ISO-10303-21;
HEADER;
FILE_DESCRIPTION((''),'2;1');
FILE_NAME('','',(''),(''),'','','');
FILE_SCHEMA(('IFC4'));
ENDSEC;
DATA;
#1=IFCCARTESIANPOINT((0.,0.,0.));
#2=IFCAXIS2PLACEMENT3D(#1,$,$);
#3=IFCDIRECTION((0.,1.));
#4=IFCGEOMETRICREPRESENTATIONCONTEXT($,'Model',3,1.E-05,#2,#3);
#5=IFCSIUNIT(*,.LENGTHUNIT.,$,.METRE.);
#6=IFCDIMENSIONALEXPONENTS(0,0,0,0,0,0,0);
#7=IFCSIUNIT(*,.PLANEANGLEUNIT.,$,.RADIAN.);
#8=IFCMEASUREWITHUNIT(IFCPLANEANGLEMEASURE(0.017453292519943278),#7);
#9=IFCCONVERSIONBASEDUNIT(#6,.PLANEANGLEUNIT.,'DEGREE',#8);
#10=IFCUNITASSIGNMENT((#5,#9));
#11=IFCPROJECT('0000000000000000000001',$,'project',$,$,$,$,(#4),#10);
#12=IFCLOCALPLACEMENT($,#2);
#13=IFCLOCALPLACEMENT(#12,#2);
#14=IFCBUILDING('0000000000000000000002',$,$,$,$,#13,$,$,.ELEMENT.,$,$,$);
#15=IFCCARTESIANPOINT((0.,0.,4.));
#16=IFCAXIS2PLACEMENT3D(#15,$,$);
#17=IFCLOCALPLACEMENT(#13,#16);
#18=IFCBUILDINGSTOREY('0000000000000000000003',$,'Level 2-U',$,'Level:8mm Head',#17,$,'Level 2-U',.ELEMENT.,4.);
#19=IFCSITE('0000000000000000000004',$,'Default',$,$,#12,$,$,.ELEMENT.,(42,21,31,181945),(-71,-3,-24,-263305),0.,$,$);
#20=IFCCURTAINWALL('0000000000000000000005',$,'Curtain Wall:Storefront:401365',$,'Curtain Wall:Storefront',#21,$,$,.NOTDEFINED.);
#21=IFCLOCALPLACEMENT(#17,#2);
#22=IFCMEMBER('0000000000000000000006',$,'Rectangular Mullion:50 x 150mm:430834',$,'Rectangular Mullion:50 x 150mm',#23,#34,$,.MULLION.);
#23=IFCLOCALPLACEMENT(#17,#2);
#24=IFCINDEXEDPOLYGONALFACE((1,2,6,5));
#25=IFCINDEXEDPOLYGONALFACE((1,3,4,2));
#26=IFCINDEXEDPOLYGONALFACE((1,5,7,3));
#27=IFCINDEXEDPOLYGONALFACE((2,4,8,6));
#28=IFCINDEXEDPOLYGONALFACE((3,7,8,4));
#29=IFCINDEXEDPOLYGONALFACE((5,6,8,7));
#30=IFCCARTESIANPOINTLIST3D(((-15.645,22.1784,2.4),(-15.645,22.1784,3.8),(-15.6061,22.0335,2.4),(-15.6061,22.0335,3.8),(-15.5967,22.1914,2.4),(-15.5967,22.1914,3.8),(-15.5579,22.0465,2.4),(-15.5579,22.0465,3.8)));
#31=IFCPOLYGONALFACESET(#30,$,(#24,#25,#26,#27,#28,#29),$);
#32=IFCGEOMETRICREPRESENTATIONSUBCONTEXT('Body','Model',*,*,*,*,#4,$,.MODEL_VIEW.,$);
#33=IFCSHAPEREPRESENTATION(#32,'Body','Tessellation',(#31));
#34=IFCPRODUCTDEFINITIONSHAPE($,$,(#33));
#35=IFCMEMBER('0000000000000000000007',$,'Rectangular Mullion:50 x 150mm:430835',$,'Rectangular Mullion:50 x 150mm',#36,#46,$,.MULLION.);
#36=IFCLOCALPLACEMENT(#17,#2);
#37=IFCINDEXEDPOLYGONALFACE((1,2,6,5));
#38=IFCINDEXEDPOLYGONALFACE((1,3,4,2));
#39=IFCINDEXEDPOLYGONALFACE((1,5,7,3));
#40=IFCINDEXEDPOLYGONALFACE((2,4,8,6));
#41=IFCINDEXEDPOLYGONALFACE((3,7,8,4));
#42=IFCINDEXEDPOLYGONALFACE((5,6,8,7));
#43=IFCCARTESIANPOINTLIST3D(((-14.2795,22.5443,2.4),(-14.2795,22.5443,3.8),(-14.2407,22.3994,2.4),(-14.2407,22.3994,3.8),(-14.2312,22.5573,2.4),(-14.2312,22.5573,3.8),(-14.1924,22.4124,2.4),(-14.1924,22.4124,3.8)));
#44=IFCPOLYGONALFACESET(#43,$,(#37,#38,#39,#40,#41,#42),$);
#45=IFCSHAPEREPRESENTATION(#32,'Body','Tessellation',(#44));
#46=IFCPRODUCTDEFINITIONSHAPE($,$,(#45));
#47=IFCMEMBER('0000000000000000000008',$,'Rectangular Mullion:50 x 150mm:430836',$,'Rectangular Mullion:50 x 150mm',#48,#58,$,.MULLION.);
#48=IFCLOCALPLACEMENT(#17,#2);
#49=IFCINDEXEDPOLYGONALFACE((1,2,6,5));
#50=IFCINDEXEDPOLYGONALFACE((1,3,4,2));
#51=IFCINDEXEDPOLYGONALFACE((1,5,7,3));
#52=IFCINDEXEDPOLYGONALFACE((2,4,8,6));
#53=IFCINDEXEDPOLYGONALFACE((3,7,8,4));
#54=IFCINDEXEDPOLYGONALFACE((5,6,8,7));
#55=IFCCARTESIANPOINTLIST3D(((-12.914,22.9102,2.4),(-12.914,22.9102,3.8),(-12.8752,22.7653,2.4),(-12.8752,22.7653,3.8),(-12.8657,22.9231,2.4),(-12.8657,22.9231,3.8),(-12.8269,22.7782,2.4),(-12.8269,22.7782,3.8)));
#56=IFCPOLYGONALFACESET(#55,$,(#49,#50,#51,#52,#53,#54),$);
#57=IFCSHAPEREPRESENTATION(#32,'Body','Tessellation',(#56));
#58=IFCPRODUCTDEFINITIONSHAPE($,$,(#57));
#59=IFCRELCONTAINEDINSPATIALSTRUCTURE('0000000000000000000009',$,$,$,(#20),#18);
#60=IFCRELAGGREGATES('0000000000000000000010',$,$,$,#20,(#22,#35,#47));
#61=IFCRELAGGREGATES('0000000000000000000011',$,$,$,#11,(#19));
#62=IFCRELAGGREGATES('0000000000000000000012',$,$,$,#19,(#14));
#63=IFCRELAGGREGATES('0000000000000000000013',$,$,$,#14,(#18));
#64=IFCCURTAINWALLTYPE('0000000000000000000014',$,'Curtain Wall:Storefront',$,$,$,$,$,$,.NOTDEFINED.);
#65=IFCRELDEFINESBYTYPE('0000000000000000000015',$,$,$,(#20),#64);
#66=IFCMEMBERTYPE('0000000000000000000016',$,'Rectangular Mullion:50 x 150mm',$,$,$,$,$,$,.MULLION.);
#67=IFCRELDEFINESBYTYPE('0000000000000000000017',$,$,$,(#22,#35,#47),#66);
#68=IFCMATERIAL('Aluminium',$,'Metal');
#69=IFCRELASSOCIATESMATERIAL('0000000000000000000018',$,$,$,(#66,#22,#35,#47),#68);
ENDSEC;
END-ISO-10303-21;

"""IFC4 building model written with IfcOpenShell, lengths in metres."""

from ifc_helpers import new_model, entity, si_unit, converted_unit, direction, frame, origin, place, context, subcontext, project, spatial, indexed_curve, outline, extrude, source, transform, mapped, material, type_object, type_shapes, element, aggregate, save


model = new_model("IFC4")

# Units and contexts
model_context = context("Model", 3, precision=1e-05, world=origin(), true_north=direction((0.0, 1.0)))
body_context = subcontext(model_context, "Body", "Model", "MODEL_VIEW")
ifc_project = project(units=[si_unit("LENGTHUNIT", "METRE"), converted_unit("PLANEANGLEUNIT", "DEGREE", entity("IfcPlaneAngleMeasure", 0.017453292519943278), si_unit("PLANEANGLEUNIT", "RADIAN"), dimensions=[0, 0, 0, 0, 0, 0, 0])], contexts=[model_context])

# Site, building, storey
site_placement = place(None, origin())
site = spatial("IfcSite", under=ifc_project, at=site_placement, Name="Default", CompositionType="ELEMENT", RefLatitude=(42, 21, 31, 181945), RefLongitude=(-71, -3, -24, -263305), RefElevation=0.0)
building_placement = place(site_placement, origin())
building = spatial("IfcBuilding", under=site, at=building_placement, CompositionType="ELEMENT")
storey_placement = place(building_placement, frame((0.0, 0.0, 4.0)))
storey = spatial("IfcBuildingStorey", under=building, at=storey_placement, Name="Level 2-U", ObjectType="Level:8mm Head", LongName="Level 2-U", CompositionType="ELEMENT", Elevation=4.0)

# Curtain wall, members
curtain_wall_type = type_object("IfcCurtainWallType", Name="Curtain Wall:Storefront", PredefinedType="NOTDEFINED")
curtain_wall_placement = place(storey_placement, frame((0.0, 0.0, -4.0)))
curtain_wall = element("IfcCurtainWall", 1, at=curtain_wall_placement, inside=storey, type_object=curtain_wall_type, Name="Curtain Wall:Storefront:401365", ObjectType="Curtain Wall:Storefront", PredefinedType="NOTDEFINED")
ifc_material_1 = material(Name="Aluminium", Category="Metal")
member_type_1 = type_object("IfcMemberType", Name="Rectangular Mullion:50 x 150mm", PredefinedType="MULLION", material=ifc_material_1)
shared_shape_1 = source(origin(), body_context, "Body", "SweptSolid", [
    extrude(outline(indexed_curve([(-0.025, -0.075), (0.025, -0.075), (0.025, 0.075), (-0.025, 0.075), (-0.025, -0.075)], self_intersect=False)), frame((0.0, 0.0, -1.4), z_axis=(0.0, 0.0, 1.0), x_axis=(-1.0, 0.0, 0.0)), (0.0, 0.0, 1.0), 1.4),
])
type_shapes(member_type_1, [shared_shape_1])
member_1_placement = place(curtain_wall_placement, frame((-15.6014, 22.1125, 6.4), z_axis=(0.0, 0.0, -1.0), x_axis=(0.965926, 0.258819, 0.0)))
member_1 = element("IfcMember", 2, at=member_1_placement, type_object=member_type_1, material=ifc_material_1, Name="Rectangular Mullion:50 x 150mm:430834", ObjectType="Rectangular Mullion:50 x 150mm", PredefinedType="MULLION", context=body_context, shape_type="MappedRepresentation", body=[
    mapped(shared_shape_1, transform((0.0, 0.0, 0.0), scale=1.0)),
])
member_2_placement = place(curtain_wall_placement, frame((-14.2359, 22.4783, 6.4), z_axis=(0.0, 0.0, -1.0), x_axis=(0.965926, 0.258819, 0.0)))
member_2 = element("IfcMember", 3, at=member_2_placement, type_object=member_type_1, material=ifc_material_1, Name="Rectangular Mullion:50 x 150mm:430835", ObjectType="Rectangular Mullion:50 x 150mm", PredefinedType="MULLION", context=body_context, shape_type="MappedRepresentation", body=[
    mapped(shared_shape_1, transform((0.0, 0.0, 0.0), scale=1.0)),
])
member_3_placement = place(curtain_wall_placement, frame((-12.8705, 22.8442, 6.4), z_axis=(0.0, 0.0, -1.0), x_axis=(0.965926, 0.258819, 0.0)))
member_3 = element("IfcMember", 4, at=member_3_placement, type_object=member_type_1, material=ifc_material_1, Name="Rectangular Mullion:50 x 150mm:430836", ObjectType="Rectangular Mullion:50 x 150mm", PredefinedType="MULLION", context=body_context, shape_type="MappedRepresentation", body=[
    mapped(shared_shape_1, transform((0.0, 0.0, 0.0), scale=1.0)),
])
aggregate(curtain_wall, [member_1, member_2, member_3])

save(model, "model.ifc")
